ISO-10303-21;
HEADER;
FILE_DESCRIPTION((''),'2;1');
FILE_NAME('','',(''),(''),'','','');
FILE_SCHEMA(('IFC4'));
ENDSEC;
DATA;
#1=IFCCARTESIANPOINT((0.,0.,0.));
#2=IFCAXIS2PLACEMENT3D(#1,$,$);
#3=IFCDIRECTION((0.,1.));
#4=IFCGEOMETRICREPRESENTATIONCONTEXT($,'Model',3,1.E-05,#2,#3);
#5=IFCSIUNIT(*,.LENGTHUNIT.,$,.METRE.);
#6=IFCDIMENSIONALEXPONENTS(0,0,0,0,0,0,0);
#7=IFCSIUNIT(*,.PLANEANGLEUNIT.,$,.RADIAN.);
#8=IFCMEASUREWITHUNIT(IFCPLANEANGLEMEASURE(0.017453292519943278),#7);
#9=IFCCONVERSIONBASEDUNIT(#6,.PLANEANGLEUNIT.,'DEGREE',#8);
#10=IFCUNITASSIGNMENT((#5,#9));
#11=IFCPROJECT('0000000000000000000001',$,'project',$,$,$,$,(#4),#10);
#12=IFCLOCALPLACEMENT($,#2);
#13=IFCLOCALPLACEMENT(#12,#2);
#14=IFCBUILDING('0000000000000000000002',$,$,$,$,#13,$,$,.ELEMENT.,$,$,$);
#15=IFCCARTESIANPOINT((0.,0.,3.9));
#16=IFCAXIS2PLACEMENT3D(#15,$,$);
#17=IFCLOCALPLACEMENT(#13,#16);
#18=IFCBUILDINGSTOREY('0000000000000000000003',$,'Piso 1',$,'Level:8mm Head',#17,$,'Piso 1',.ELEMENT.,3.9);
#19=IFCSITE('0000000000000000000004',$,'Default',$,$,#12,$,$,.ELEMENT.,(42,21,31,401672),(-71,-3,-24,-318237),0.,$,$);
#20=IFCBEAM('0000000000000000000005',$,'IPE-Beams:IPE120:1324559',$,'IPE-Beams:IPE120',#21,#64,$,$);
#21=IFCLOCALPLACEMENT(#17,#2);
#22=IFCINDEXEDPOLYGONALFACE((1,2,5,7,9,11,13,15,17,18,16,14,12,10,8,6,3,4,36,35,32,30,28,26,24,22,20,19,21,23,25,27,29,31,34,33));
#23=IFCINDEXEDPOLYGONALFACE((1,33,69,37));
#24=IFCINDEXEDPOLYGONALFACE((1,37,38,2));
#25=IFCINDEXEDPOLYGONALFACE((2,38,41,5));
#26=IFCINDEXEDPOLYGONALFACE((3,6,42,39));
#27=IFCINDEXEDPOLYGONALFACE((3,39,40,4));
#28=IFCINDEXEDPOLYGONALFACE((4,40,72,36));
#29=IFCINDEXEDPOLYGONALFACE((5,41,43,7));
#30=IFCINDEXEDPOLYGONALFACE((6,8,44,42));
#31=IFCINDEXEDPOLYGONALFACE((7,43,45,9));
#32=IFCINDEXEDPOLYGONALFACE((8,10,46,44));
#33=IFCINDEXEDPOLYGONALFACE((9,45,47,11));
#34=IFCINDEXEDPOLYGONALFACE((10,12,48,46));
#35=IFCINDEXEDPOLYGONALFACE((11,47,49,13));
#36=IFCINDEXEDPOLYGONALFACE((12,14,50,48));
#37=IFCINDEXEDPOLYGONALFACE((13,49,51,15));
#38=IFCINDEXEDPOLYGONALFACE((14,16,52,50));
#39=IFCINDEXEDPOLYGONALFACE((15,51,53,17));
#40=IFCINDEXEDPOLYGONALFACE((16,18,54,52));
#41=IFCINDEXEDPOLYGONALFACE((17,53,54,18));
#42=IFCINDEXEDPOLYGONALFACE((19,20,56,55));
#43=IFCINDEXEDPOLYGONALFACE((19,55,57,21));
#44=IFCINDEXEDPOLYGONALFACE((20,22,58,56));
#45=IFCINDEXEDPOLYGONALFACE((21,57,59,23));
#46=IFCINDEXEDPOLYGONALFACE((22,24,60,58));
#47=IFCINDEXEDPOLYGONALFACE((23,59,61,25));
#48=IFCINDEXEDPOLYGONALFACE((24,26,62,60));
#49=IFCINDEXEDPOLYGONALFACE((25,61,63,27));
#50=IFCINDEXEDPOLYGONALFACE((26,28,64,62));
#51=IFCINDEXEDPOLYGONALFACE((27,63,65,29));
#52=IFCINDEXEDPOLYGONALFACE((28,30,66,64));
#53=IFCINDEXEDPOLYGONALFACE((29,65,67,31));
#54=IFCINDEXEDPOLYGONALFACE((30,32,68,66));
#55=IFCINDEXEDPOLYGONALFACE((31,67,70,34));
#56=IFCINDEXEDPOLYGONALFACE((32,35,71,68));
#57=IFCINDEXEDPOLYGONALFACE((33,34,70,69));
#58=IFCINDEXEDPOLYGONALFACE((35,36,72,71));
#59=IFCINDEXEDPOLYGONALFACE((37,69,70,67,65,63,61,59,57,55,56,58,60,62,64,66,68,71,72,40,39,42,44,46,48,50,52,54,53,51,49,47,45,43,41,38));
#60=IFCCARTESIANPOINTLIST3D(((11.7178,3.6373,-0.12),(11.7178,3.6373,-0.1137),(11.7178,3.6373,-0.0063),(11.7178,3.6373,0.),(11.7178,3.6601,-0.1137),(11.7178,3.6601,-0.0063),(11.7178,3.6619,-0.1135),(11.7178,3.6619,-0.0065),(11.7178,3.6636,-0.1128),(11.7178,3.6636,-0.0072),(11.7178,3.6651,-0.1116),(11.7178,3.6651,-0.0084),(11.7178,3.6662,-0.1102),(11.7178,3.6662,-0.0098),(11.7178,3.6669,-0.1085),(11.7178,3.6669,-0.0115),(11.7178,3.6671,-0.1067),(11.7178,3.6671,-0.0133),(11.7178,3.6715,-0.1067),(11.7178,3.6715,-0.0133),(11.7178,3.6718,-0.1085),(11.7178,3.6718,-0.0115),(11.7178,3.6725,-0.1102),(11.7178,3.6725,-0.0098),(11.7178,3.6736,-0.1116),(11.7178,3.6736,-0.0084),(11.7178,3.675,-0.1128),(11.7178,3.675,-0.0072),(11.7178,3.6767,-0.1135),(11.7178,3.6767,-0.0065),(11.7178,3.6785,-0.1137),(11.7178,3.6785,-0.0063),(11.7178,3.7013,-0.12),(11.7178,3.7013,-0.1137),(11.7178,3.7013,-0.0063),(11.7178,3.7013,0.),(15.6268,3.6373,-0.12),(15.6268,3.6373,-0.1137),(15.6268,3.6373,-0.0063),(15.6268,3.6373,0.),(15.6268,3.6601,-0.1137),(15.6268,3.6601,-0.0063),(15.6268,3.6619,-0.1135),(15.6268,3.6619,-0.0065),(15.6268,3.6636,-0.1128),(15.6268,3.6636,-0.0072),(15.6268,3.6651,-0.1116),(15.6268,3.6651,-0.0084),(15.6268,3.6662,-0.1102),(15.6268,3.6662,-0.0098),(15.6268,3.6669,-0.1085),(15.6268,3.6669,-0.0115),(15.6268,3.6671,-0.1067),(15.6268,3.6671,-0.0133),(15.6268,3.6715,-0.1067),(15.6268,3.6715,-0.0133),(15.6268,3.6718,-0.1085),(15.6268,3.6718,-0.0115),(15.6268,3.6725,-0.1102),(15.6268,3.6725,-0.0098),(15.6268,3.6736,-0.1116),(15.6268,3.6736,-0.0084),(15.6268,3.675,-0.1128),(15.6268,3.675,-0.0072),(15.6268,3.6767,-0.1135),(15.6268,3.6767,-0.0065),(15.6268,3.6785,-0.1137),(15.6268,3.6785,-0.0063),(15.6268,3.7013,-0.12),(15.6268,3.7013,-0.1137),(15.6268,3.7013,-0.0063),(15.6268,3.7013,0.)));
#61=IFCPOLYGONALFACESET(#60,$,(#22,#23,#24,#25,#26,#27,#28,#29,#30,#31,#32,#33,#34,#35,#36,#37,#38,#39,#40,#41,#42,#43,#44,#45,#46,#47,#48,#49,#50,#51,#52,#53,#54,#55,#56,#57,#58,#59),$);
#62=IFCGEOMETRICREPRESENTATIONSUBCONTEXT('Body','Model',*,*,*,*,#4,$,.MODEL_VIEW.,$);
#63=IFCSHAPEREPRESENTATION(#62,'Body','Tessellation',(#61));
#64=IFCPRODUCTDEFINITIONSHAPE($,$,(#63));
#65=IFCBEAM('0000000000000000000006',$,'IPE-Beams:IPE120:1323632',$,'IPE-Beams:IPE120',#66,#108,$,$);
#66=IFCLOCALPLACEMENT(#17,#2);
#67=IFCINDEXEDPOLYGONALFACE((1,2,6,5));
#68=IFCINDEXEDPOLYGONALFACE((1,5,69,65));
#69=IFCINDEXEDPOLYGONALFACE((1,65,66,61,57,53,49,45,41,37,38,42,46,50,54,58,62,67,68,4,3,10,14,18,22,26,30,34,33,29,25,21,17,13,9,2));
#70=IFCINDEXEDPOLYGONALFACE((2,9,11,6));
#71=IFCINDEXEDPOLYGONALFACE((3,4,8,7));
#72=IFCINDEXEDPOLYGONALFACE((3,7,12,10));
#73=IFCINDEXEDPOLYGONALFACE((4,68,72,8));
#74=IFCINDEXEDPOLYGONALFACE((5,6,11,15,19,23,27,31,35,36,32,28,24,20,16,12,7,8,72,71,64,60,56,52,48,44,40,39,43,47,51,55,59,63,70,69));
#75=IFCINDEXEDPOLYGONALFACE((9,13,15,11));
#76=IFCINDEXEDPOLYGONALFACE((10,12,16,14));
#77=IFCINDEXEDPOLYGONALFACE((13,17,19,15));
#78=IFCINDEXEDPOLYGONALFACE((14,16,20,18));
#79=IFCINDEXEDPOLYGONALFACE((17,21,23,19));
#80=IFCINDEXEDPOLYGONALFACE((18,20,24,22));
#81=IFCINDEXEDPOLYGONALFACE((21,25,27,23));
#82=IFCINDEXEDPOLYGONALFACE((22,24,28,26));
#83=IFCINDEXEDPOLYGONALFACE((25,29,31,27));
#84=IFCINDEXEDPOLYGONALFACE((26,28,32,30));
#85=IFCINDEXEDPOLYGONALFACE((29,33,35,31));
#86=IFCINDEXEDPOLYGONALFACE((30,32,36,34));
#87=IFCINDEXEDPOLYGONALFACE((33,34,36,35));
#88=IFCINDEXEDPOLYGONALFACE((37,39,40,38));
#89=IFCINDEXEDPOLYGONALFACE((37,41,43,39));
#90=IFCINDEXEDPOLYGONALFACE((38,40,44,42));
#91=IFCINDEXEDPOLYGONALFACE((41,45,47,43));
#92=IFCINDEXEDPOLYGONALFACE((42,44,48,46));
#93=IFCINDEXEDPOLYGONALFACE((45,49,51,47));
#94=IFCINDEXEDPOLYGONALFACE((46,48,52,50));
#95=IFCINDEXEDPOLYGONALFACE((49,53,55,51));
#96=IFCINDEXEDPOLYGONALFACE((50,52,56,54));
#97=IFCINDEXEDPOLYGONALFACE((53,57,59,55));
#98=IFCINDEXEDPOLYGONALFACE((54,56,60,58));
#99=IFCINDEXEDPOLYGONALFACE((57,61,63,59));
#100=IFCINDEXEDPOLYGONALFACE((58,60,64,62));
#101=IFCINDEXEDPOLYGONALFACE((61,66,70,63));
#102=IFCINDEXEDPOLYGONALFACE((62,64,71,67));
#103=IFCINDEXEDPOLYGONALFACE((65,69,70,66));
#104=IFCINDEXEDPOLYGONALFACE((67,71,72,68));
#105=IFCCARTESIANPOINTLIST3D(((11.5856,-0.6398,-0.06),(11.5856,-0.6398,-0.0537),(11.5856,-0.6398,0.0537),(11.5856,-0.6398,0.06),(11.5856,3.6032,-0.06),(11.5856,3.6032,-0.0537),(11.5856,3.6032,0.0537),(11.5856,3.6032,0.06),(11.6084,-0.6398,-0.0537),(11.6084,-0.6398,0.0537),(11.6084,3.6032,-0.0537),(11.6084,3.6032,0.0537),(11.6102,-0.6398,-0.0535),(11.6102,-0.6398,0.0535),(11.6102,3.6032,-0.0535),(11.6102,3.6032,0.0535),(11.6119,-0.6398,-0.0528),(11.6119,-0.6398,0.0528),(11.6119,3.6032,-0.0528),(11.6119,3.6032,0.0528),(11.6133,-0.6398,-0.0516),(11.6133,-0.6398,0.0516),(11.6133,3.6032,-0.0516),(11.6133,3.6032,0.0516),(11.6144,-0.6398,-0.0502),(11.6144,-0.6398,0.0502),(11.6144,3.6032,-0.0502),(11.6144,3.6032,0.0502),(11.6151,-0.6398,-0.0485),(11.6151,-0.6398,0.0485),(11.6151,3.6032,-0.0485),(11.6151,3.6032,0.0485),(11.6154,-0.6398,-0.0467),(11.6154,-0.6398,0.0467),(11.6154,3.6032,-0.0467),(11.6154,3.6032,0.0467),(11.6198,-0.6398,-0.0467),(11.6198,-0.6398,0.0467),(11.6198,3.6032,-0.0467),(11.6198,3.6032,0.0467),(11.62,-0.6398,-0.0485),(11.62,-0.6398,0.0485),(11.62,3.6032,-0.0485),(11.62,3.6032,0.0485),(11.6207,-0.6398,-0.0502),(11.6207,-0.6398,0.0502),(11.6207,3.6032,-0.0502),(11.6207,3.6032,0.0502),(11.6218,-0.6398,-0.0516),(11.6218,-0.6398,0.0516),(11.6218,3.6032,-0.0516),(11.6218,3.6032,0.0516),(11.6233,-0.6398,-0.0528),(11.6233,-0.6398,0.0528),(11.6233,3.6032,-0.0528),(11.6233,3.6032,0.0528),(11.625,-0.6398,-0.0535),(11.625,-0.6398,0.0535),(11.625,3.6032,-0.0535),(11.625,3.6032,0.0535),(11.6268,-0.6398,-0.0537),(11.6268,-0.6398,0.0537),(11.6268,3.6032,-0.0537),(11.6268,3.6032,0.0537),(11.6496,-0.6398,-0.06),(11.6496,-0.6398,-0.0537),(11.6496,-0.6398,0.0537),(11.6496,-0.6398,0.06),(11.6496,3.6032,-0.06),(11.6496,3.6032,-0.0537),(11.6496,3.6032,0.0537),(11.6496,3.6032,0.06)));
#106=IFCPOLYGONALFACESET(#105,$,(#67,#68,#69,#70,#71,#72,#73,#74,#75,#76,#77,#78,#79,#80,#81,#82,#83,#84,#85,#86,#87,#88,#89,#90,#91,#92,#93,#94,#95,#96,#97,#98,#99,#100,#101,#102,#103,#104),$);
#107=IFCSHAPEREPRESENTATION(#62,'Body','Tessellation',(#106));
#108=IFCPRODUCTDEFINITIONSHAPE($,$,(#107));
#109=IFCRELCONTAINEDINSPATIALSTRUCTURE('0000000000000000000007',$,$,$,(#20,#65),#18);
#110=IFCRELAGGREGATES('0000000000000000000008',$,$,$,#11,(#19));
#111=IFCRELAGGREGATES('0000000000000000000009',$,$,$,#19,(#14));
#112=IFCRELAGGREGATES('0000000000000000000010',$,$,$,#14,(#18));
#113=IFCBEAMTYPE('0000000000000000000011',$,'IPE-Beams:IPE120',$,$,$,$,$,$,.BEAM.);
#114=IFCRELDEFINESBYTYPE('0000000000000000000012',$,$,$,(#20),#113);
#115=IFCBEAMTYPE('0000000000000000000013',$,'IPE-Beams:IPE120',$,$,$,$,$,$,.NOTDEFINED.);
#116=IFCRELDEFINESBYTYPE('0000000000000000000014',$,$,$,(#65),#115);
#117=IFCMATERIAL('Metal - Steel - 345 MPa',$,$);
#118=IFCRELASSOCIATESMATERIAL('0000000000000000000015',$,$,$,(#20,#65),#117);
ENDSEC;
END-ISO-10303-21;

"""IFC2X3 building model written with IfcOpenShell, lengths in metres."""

from ifc_helpers import new_model, entity, si_unit, converted_unit, direction, frame, frame_2d, origin, place, context, subcontext, project, spatial, i_section, extrude, material, type_object, element, save


model = new_model("IFC2X3")

# Units and contexts
model_context = context("Model", 3, precision=1e-05, world=origin(), true_north=direction((0.0, 1.0)))
body_context = subcontext(model_context, "Body", "Model", "MODEL_VIEW")
ifc_project = project(units=[si_unit("LENGTHUNIT", "METRE"), converted_unit("PLANEANGLEUNIT", "DEGREE", entity("IfcPlaneAngleMeasure", 0.017453292519943278), si_unit("PLANEANGLEUNIT", "RADIAN"), dimensions=[0, 0, 0, 0, 0, 0, 0])], contexts=[model_context])

# Site, building, storey
site_placement = place(None, origin())
site = spatial("IfcSite", under=ifc_project, at=site_placement, Name="Default", CompositionType="ELEMENT", RefLatitude=(42, 21, 31, 401672), RefLongitude=(-71, -3, -24, -318237), RefElevation=0.0)
building_placement = place(site_placement, origin())
building = spatial("IfcBuilding", under=site, at=building_placement, CompositionType="ELEMENT")
storey_placement = place(building_placement, frame((0.0, 0.0, 3.9)))
storey = spatial("IfcBuildingStorey", under=building, at=storey_placement, Name="Piso 1", ObjectType="Level:8mm Head", LongName="Piso 1", CompositionType="ELEMENT", Elevation=3.9)

# Beam
ifc_material = material(Name="Metal - Steel - 345 MPa")
beam_type_1 = type_object("IfcBeamType", Name="IPE-Beams:IPE120", PredefinedType="BEAM")
beam_1_placement = place(storey_placement, frame((11.6176, 3.6693, 0.0)))
element("IfcBeam", 1, at=beam_1_placement, inside=storey, type_object=beam_type_1, material=ifc_material, Name="IPE-Beams:IPE120:1324559", ObjectType="IPE-Beams:IPE120", context=body_context, shape_type="SweptSolid", body=[
    extrude(i_section(OverallWidth=0.064, OverallDepth=0.12, WebThickness=0.0044, FlangeThickness=0.0063, FilletRadius=0.007, at=frame_2d((0.0, 0.0), x_axis=(0.0, 1.0))), frame((0.1002, 0.0, -0.06), z_axis=(1.0, 0.0, 0.0), x_axis=(0.0, 0.0, -1.0)), (0.0, 0.0, 1.0), 3.909),
])

# Beam
beam_type_2 = type_object("IfcBeamType", Name="IPE-Beams:IPE120", PredefinedType="NOTDEFINED")
beam_2_placement = place(storey_placement, frame((11.6176, 3.6661, 0.0), z_axis=(0.0, 0.0, 1.0), x_axis=(0.0, -1.0, 0.0)))
element("IfcBeam", 2, at=beam_2_placement, inside=storey, type_object=beam_type_2, material=ifc_material, Name="IPE-Beams:IPE120:1323632", ObjectType="IPE-Beams:IPE120", context=body_context, shape_type="SweptSolid", body=[
    extrude(i_section(OverallWidth=0.064, OverallDepth=0.12, WebThickness=0.0044, FlangeThickness=0.0063, FilletRadius=0.007, at=frame_2d((0.0, 0.0), x_axis=(0.0, 1.0))), frame((0.0629, 0.0, 0.0), z_axis=(1.0, 0.0, 0.0), x_axis=(0.0, 0.0, -1.0)), (0.0, 0.0, 1.0), 4.243),
])

save(model, "model.ifc")
